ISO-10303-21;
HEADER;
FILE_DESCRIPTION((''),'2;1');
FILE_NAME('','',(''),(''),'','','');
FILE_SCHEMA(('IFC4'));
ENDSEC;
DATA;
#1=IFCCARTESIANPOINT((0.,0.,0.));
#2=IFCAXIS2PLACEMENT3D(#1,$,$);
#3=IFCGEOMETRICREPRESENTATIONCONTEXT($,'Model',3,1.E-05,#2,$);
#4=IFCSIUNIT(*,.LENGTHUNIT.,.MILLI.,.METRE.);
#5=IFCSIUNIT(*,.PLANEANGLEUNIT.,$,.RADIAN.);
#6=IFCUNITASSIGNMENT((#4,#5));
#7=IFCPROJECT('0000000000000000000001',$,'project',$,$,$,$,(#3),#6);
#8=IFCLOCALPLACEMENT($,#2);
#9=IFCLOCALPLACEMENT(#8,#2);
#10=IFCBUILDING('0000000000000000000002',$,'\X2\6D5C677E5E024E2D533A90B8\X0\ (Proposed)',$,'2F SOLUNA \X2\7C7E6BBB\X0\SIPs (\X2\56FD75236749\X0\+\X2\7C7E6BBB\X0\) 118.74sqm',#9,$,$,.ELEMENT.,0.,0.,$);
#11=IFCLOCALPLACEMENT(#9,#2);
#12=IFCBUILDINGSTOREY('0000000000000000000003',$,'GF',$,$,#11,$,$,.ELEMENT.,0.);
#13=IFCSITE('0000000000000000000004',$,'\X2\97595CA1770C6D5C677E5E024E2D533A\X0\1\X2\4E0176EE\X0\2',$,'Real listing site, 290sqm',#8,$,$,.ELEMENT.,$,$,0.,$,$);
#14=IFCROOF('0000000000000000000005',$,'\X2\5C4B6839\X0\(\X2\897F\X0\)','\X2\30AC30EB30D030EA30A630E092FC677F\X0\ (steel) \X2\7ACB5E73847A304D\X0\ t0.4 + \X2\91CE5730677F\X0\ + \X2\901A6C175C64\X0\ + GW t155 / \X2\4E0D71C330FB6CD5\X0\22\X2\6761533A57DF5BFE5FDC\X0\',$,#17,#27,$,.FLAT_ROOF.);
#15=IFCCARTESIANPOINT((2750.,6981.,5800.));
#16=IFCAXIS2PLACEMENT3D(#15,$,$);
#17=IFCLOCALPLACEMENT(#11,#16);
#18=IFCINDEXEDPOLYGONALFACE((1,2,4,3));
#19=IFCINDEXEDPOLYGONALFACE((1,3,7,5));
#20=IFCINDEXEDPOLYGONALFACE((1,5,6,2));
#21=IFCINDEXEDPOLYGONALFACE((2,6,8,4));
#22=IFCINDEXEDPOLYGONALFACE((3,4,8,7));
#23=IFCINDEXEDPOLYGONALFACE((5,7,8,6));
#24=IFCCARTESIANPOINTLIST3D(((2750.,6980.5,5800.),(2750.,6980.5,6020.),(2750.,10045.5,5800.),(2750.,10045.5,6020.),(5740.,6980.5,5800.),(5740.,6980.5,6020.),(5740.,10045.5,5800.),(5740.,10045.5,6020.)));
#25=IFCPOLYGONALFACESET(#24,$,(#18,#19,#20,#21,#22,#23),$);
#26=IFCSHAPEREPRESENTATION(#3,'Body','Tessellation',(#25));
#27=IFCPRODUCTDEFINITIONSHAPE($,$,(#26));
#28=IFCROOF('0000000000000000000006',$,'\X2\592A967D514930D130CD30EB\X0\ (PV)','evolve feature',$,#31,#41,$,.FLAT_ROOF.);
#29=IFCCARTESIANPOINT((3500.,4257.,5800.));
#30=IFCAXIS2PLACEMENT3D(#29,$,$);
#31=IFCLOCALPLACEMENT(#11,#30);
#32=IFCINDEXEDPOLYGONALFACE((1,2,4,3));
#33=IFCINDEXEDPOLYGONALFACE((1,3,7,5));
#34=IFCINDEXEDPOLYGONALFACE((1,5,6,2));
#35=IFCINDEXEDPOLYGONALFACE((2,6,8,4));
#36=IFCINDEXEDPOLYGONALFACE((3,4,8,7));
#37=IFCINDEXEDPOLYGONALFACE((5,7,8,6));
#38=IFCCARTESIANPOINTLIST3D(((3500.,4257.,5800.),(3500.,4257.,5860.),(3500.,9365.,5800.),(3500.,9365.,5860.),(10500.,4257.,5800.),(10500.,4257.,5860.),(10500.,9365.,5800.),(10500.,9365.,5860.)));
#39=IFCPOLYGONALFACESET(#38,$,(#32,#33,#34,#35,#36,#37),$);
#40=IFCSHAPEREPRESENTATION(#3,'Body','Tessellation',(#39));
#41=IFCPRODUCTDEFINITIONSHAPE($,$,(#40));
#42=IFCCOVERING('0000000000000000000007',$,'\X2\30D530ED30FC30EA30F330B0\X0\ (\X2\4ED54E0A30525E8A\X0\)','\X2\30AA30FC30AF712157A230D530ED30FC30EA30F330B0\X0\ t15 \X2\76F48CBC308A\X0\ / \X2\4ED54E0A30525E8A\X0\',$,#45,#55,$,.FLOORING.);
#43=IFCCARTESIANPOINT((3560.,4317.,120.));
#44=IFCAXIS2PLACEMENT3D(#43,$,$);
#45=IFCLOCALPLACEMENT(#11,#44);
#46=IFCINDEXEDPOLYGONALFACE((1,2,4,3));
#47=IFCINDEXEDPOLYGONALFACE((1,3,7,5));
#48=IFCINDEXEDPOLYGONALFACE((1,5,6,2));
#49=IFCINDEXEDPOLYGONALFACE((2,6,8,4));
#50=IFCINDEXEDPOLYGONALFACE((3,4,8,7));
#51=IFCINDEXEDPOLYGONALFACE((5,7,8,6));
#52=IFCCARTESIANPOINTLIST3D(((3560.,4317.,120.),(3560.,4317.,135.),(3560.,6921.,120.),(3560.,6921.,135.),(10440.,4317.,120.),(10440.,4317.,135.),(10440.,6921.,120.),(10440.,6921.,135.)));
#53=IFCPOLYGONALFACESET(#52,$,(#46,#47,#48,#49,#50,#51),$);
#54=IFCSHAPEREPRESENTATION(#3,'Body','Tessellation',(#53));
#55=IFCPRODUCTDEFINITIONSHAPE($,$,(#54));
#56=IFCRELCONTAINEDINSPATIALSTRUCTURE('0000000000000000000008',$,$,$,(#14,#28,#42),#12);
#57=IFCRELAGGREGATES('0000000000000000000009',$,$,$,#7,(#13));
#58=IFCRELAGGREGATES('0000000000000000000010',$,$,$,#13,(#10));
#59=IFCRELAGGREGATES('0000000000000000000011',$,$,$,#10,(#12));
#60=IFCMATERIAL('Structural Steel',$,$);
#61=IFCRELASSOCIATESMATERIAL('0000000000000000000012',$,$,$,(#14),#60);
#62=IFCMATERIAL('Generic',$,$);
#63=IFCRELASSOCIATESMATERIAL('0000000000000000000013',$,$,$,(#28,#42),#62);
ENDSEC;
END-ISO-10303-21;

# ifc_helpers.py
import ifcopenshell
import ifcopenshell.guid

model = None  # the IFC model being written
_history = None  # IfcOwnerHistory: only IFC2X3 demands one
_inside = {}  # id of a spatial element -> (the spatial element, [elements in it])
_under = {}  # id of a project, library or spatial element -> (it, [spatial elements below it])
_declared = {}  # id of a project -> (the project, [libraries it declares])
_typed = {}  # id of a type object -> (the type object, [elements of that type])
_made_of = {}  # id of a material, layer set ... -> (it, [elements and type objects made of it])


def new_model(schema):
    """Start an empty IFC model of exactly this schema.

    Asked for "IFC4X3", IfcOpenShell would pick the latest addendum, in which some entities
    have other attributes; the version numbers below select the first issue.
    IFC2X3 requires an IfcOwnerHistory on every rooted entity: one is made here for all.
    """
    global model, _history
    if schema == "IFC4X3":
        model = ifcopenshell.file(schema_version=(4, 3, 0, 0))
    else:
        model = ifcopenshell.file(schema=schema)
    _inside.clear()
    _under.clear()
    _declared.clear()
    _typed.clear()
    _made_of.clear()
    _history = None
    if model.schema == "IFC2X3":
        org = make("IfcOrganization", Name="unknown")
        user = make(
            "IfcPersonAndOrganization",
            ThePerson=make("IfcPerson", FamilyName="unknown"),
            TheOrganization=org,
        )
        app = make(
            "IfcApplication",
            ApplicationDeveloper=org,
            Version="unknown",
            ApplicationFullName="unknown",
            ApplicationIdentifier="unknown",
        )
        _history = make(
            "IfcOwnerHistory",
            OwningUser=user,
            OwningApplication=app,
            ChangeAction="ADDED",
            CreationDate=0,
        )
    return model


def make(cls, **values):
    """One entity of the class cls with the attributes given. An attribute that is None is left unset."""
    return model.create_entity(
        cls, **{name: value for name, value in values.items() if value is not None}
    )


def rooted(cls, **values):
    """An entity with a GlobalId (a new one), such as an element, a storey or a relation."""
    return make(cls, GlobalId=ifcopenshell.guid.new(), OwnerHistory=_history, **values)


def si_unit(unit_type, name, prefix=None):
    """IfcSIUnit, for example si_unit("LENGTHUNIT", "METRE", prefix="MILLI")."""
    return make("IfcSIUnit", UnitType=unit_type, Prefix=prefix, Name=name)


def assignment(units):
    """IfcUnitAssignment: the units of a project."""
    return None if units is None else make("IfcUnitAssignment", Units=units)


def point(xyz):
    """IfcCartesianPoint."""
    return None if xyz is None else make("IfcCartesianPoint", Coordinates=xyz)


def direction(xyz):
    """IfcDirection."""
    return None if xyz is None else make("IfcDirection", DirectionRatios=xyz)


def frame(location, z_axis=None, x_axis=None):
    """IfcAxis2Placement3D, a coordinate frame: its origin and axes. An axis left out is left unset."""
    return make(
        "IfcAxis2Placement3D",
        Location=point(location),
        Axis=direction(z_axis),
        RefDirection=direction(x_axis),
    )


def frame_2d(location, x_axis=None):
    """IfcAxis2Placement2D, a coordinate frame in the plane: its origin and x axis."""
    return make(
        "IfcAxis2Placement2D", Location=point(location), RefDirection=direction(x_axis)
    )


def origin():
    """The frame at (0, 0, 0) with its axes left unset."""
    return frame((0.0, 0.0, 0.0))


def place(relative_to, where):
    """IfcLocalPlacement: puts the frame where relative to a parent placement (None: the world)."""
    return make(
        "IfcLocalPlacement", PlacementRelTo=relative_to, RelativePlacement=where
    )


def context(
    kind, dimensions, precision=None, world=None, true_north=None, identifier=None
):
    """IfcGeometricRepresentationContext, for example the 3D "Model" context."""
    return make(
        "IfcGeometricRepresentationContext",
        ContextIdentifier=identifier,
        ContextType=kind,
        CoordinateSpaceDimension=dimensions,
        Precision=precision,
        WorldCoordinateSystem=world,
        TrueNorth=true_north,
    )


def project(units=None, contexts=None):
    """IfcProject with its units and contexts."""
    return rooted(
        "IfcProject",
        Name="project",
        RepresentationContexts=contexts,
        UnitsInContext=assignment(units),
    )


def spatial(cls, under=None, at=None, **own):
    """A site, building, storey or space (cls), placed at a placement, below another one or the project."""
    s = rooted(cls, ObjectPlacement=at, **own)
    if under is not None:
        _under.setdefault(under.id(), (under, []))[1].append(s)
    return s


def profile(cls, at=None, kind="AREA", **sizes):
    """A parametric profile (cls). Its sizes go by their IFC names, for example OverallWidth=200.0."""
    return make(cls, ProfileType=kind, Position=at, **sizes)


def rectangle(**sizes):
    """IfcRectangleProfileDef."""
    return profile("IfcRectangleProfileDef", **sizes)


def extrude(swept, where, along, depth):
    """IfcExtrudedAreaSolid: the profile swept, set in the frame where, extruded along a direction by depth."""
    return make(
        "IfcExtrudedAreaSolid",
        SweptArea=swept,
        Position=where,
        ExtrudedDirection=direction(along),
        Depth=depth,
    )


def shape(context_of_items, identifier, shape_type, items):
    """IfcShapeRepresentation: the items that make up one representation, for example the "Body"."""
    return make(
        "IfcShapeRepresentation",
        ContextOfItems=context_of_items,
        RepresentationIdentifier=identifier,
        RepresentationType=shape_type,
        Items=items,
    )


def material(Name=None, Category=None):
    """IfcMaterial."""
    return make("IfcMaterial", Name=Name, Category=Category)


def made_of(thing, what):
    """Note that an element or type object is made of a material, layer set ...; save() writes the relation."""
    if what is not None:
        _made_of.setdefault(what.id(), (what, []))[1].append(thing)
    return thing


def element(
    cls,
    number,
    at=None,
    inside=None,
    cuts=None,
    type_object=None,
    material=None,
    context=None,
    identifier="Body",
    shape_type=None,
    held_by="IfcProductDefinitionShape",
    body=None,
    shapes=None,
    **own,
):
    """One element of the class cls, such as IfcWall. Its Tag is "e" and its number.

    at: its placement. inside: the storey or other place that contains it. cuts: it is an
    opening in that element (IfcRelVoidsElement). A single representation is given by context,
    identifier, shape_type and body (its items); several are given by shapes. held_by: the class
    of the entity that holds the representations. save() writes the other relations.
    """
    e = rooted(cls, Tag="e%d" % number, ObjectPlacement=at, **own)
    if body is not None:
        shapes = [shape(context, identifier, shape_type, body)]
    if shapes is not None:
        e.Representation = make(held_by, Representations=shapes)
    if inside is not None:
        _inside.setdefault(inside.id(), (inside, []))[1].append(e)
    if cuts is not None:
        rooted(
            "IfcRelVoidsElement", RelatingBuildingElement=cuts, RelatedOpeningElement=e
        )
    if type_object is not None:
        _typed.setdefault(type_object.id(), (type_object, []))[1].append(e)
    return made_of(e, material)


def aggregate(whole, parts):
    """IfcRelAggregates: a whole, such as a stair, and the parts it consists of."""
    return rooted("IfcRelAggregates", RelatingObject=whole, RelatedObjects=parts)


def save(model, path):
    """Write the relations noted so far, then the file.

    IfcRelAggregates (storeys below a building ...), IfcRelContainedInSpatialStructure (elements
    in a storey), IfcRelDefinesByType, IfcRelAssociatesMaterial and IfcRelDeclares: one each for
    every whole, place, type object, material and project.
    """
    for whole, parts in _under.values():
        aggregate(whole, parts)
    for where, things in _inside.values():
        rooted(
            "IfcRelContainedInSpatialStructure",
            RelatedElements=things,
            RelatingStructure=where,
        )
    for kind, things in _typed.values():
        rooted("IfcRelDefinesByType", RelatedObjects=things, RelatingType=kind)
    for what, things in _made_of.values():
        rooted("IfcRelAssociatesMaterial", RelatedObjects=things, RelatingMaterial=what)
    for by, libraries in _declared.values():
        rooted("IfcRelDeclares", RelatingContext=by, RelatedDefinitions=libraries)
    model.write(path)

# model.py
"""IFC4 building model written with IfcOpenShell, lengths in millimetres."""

from ifc_helpers import new_model, si_unit, frame, frame_2d, origin, place, context, project, spatial, rectangle, extrude, material, element, save


model = new_model("IFC4")

# Units and contexts
model_context = context("Model", 3, precision=1e-05, world=origin())
ifc_project = project(units=[si_unit("LENGTHUNIT", "METRE", prefix="MILLI"), si_unit("PLANEANGLEUNIT", "RADIAN")], contexts=[model_context])

# Site, building, storey
site_placement = place(None, origin())
site = spatial("IfcSite", under=ifc_project, at=site_placement, Name="静岡県浜松市中区1丁目2", ObjectType="Real listing site, 290sqm", CompositionType="ELEMENT", RefElevation=0.0)
building_placement = place(site_placement, origin())
building = spatial("IfcBuilding", under=site, at=building_placement, Name="浜松市中区邸 (Proposed)", ObjectType="2F SOLUNA 籾殻SIPs (国産杉+籾殻) 118.74sqm", CompositionType="ELEMENT", ElevationOfRefHeight=0.0, ElevationOfTerrain=0.0)
storey_placement = place(building_placement, origin())
storey = spatial("IfcBuildingStorey", under=building, at=storey_placement, Name="GF", CompositionType="ELEMENT", Elevation=0.0)

# Shared definitions
ifc_material_1 = material(Name="Generic")

# Roofs
ifc_material_2 = material(Name="Structural Steel")
roof_1_placement = place(storey_placement, frame((2750.0, 6981.0, 5800.0)))
element("IfcRoof", 1, at=roof_1_placement, inside=storey, material=ifc_material_2, Name="屋根(西)", Description="ガルバリウム鋼板 (steel) 立平葺き t0.4 + 野地板 + 通気層 + GW t155 / 不燃・法22条区域対応", PredefinedType="FLAT_ROOF", context=model_context, shape_type="SweptSolid", body=[
    extrude(rectangle(XDim=2990.0, YDim=3065.0, at=frame_2d((1495.0, 1532.0))), frame((2750.0, 6981.0, 5800.0)), (0.0, 0.0, 1.0), 220.0),
])
roof_2_placement = place(storey_placement, frame((3500.0, 4257.0, 5800.0)))
element("IfcRoof", 2, at=roof_2_placement, inside=storey, material=ifc_material_1, Name="太陽光パネル (PV)", Description="evolve feature", PredefinedType="FLAT_ROOF", context=model_context, shape_type="SweptSolid", body=[
    extrude(rectangle(XDim=7000.0, YDim=5108.0, at=frame_2d((3500.0, 2554.0))), frame((3500.0, 4257.0, 5800.0)), (0.0, 0.0, 1.0), 60.0),
])

# Covering
covering_placement = place(storey_placement, frame((3560.0, 4317.0, 120.0)))
element("IfcCovering", 3, at=covering_placement, inside=storey, material=ifc_material_1, Name="フローリング (仕上げ床)", Description="オーク無垢フローリング t15 直貼り / 仕上げ床", PredefinedType="FLOORING", context=model_context, shape_type="SweptSolid", body=[
    extrude(rectangle(XDim=6880.0, YDim=2604.0, at=frame_2d((3440.0, 1302.0))), frame((3560.0, 4317.0, 120.0)), (0.0, 0.0, 1.0), 15.0),
])

save(model, "model.ifc")
